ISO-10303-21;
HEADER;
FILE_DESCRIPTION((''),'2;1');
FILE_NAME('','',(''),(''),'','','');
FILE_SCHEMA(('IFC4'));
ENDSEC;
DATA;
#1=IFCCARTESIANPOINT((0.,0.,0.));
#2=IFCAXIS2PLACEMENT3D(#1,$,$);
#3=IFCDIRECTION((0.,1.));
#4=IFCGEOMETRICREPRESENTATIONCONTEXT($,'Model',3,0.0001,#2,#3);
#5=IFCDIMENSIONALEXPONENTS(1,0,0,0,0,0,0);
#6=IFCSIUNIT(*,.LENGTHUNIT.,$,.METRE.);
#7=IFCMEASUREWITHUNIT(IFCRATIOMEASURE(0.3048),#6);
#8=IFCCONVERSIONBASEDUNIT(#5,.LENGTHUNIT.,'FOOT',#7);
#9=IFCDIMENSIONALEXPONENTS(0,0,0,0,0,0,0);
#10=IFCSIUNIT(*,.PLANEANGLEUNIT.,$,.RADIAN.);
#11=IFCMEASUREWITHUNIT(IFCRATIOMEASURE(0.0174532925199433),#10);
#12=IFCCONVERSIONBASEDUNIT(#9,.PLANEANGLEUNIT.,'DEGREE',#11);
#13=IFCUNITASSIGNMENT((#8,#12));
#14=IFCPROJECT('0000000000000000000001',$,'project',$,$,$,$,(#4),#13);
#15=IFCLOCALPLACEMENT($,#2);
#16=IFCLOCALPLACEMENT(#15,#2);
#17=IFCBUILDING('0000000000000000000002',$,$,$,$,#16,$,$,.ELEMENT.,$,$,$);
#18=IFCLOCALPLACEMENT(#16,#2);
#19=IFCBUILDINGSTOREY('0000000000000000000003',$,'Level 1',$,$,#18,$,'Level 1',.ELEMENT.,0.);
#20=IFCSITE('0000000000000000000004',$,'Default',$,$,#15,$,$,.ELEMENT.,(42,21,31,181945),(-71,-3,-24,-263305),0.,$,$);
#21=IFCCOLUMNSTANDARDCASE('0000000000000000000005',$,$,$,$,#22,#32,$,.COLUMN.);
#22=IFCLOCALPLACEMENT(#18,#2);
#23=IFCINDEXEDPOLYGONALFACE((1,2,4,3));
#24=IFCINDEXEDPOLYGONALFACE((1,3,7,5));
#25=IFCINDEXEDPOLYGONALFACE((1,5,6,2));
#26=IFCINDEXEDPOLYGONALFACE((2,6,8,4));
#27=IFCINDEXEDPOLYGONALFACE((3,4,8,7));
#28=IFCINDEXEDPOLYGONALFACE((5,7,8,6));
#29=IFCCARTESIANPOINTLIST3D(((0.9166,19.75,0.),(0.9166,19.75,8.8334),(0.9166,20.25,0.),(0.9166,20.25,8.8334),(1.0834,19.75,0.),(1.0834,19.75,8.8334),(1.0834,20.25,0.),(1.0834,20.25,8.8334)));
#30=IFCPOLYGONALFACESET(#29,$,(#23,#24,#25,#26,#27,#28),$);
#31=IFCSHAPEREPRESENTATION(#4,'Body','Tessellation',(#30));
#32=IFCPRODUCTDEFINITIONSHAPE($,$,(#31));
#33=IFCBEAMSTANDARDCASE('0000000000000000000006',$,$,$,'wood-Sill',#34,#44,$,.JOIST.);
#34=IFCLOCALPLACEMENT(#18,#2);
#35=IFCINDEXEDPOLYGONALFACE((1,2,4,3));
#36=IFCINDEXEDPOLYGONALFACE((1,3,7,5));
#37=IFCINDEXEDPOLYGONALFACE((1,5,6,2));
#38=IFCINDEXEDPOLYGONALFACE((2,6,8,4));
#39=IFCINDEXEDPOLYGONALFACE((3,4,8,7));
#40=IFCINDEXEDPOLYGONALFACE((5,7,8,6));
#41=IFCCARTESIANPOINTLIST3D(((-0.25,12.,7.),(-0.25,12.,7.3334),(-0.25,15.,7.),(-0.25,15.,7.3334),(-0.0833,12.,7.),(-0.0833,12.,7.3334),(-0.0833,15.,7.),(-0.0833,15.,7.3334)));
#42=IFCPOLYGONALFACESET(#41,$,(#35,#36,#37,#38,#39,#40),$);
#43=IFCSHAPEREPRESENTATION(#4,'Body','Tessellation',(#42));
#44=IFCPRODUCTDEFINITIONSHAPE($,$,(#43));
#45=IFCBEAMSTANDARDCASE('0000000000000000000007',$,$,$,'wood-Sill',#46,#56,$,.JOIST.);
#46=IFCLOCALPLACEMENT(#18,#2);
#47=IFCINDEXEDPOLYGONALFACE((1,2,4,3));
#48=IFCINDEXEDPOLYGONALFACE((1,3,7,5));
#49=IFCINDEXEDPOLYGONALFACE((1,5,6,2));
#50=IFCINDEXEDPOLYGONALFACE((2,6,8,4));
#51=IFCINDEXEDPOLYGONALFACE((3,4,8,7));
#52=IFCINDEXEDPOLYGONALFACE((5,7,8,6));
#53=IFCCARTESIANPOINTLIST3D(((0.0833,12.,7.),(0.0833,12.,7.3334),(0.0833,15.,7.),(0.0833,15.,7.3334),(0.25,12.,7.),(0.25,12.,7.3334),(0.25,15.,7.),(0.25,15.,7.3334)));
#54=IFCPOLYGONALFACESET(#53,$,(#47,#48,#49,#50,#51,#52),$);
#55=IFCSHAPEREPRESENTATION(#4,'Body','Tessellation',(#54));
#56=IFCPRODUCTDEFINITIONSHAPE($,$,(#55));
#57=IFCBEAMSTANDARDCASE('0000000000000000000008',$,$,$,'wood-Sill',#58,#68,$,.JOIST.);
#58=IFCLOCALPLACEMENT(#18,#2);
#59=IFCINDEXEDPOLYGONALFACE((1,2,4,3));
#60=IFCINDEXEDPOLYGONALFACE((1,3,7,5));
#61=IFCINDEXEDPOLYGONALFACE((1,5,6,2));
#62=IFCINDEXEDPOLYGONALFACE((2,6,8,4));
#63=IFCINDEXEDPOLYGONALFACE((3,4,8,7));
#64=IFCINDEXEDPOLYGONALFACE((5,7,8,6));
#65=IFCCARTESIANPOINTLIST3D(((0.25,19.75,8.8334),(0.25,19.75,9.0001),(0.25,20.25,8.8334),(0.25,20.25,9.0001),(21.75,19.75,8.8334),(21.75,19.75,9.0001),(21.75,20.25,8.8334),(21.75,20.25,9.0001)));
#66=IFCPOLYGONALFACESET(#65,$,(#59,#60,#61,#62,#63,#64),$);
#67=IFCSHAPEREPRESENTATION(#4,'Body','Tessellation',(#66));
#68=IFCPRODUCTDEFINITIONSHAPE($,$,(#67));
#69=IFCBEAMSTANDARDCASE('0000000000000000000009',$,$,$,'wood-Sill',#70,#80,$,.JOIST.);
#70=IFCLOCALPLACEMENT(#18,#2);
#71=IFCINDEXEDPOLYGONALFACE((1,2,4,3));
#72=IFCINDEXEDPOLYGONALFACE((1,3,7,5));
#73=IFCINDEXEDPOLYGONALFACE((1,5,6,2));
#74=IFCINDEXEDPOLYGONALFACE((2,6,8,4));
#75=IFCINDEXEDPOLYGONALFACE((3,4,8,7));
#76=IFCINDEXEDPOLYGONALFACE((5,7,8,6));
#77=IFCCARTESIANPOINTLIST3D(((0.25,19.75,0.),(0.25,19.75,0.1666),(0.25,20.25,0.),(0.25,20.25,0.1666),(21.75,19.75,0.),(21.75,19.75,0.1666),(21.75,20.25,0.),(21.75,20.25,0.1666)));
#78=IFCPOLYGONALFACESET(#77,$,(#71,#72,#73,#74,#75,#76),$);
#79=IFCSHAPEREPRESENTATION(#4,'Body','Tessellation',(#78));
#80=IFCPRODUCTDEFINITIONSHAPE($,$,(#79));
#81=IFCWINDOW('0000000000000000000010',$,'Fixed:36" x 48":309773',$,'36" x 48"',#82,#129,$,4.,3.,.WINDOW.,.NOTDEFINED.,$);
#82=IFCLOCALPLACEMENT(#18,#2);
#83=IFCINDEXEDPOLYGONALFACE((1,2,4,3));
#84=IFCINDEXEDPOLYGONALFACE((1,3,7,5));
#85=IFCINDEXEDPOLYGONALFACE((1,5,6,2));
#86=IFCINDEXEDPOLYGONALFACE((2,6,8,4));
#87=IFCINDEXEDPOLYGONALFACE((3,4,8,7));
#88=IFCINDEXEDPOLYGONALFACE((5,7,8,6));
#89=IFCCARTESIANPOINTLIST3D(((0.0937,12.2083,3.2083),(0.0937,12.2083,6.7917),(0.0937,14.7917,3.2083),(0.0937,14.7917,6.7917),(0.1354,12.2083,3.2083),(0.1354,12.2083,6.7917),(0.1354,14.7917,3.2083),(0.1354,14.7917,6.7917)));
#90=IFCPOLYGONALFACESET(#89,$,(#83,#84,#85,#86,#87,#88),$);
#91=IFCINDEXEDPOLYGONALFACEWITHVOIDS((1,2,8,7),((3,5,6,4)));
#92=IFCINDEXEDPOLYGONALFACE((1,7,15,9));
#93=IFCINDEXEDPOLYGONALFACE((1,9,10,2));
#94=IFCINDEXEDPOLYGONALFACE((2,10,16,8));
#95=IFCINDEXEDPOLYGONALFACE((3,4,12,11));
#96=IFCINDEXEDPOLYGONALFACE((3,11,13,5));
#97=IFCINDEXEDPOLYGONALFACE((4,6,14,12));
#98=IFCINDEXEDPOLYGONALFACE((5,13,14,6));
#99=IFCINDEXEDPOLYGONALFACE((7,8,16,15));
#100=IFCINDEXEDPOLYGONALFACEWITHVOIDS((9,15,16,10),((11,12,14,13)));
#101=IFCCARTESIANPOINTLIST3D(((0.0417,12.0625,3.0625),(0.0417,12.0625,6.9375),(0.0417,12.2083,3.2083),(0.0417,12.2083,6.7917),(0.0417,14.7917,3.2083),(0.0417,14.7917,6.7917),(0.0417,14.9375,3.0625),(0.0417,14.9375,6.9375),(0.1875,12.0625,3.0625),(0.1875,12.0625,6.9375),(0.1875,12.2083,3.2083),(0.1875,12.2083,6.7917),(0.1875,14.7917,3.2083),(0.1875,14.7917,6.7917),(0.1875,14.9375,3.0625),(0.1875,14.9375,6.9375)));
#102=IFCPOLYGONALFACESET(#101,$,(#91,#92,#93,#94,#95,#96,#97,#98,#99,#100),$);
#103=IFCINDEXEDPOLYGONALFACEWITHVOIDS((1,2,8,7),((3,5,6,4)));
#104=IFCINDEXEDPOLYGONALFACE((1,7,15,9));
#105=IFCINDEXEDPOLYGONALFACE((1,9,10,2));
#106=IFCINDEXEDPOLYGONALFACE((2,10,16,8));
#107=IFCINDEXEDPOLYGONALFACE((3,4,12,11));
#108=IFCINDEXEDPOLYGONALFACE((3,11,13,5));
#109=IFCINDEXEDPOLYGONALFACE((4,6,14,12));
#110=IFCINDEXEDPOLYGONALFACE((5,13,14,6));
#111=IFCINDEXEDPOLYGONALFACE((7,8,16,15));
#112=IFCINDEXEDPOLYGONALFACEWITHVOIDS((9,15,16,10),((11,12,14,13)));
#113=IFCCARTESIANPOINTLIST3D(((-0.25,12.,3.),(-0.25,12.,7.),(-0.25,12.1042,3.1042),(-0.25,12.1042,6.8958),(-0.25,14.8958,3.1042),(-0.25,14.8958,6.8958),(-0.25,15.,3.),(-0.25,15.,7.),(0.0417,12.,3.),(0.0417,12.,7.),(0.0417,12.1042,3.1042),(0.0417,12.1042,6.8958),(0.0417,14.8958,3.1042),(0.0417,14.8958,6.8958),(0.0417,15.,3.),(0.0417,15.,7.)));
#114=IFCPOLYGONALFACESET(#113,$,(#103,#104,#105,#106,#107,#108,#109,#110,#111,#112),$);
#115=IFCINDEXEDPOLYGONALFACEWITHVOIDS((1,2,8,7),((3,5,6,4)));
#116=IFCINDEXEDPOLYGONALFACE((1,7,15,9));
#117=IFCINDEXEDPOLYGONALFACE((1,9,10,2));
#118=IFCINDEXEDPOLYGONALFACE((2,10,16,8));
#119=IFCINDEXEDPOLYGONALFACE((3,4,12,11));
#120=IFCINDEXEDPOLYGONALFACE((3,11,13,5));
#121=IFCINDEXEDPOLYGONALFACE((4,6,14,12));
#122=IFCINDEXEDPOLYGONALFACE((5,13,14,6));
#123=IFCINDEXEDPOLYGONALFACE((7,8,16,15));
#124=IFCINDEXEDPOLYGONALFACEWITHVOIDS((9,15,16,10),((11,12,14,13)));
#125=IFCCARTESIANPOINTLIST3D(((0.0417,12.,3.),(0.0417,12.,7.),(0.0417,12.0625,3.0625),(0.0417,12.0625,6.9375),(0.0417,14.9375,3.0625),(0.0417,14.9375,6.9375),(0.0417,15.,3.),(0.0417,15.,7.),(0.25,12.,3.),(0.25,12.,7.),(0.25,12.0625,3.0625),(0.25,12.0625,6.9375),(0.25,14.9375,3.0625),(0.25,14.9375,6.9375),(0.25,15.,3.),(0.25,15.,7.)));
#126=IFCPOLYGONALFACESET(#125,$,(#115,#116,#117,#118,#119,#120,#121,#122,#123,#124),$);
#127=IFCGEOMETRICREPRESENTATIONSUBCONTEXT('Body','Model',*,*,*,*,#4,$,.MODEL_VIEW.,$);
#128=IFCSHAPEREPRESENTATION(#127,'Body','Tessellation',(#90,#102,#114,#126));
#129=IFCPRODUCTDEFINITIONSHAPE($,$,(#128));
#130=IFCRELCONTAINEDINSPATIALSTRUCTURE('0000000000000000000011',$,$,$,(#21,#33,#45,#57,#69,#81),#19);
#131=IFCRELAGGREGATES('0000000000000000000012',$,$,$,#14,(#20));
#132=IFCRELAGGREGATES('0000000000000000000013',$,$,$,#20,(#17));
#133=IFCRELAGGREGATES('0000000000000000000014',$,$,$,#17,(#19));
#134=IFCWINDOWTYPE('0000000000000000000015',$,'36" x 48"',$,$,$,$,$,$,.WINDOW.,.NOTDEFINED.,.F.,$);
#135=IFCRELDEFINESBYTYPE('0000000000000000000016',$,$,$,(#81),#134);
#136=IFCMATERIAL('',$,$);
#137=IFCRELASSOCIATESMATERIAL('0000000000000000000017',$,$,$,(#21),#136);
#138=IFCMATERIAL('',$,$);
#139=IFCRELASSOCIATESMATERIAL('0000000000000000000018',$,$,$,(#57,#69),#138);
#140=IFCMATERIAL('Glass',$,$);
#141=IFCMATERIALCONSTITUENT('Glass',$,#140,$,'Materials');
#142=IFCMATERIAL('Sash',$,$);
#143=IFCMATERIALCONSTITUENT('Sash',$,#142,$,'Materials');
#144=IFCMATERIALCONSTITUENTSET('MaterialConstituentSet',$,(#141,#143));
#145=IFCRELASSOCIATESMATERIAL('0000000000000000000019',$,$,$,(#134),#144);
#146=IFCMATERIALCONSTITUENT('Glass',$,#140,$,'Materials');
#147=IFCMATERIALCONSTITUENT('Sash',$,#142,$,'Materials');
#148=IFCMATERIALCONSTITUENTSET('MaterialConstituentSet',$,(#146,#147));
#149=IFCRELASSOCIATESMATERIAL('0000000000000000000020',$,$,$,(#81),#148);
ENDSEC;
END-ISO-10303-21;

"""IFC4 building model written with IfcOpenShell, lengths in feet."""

from ifc_helpers import new_model, entity, si_unit, converted_unit, direction, frame, frame_2d, origin, origin_with_axes, place, context, subcontext, project, spatial, polyline, rectangle, outline, extrude, source, transform, mapped, material, constituent, constituent_set, type_object, type_shapes, element, save


model = new_model("IFC4")

# Units and contexts
model_context = context("Model", 3, precision=0.0001, world=origin(), true_north=direction((0.0, 1.0)))
body_context = subcontext(model_context, "Body", "Model", "MODEL_VIEW")
ifc_project = project(units=[converted_unit("LENGTHUNIT", "FOOT", entity("IfcRatioMeasure", 0.3048), si_unit("LENGTHUNIT", "METRE"), dimensions=[1, 0, 0, 0, 0, 0, 0]), converted_unit("PLANEANGLEUNIT", "DEGREE", entity("IfcRatioMeasure", 0.0174532925199433), si_unit("PLANEANGLEUNIT", "RADIAN"), dimensions=[0, 0, 0, 0, 0, 0, 0])], contexts=[model_context])

# Site, building, storey
site_placement = place(None, origin())
site = spatial("IfcSite", under=ifc_project, at=site_placement, Name="Default", CompositionType="ELEMENT", RefLatitude=(42, 21, 31, 181945), RefLongitude=(-71, -3, -24, -263305), RefElevation=0.0)
building_placement = place(site_placement, origin())
building = spatial("IfcBuilding", under=site, at=building_placement, CompositionType="ELEMENT")
storey_placement = place(building_placement, origin())
storey = spatial("IfcBuildingStorey", under=building, at=storey_placement, Name="Level 1", LongName="Level 1", CompositionType="ELEMENT", Elevation=0.0)

# Column
placement_1 = place(storey_placement, frame((0.0, -0.25, 0.0), z_axis=(0.0, 0.0, 1.0), x_axis=(0.0, 1.0, 0.0)))
ifc_material_1 = material(Name="")
placement_2 = place(storey_placement, frame((0.25, 20.0, 0.0)))
for number, where, z_axis, x_axis in (
    (1, (0.75, 0.0, 0.0), (0.0, 0.0, 1.0), (1.0, 0.0, 0.0)),
):
    element("IfcColumnStandardCase", number, at=place(placement_2, frame(where, z_axis=z_axis, x_axis=x_axis)), inside=storey, material=ifc_material_1, PredefinedType="COLUMN", context=model_context, shape_type="SweptSolid", body=[
        extrude(rectangle(XDim=0.1667, YDim=0.5), origin(), (0.0, 0.0, 1.0), 8.8334),
    ])

# Beams
for number, where, z_axis, x_axis in (
    (2, (12.25, 0.1667, 7.1667), (1.0, 0.0, 0.0), (0.0, 0.0, 1.0)),
    (3, (12.25, -0.1667, 7.1667), (1.0, 0.0, 0.0), (0.0, 0.0, 1.0)),
):
    element("IfcBeamStandardCase", number, at=place(placement_1, frame(where, z_axis=z_axis, x_axis=x_axis)), inside=storey, ObjectType="wood-Sill", PredefinedType="JOIST", context=model_context, shape_type="SweptSolid", body=[
        extrude(rectangle(XDim=0.3333, YDim=0.1667), origin_with_axes(), (0.0, 0.0, 1.0), 3.0),
    ])
ifc_material_2 = material(Name="")
for number, where, z_axis, x_axis in (
    (4, (0.0, 0.0, 8.9167), (1.0, 0.0, 0.0), (0.0, 0.0, 1.0)),
    (5, (0.0, 0.0, 0.0833), (1.0, 0.0, 0.0), (0.0, 0.0, 1.0)),
):
    element("IfcBeamStandardCase", number, at=place(placement_2, frame(where, z_axis=z_axis, x_axis=x_axis)), inside=storey, material=ifc_material_2, ObjectType="wood-Sill", PredefinedType="JOIST", context=model_context, shape_type="SweptSolid", body=[
        extrude(rectangle(XDim=0.1667, YDim=0.5), origin_with_axes(), (0.0, 0.0, 1.0), 21.5),
    ])

# Window
ifc_material_3 = material(Name="Glass")
ifc_constituent_1 = constituent(ifc_material_3, Name="Glass", Category="Materials")
ifc_material_4 = material(Name="Sash")
ifc_constituent_2 = constituent(ifc_material_4, Name="Sash", Category="Materials")
ifc_constituent_set_1 = constituent_set(constituents=[ifc_constituent_1, ifc_constituent_2], Name="MaterialConstituentSet")
ifc_constituent_3 = constituent(ifc_material_3, Name="Glass", Category="Materials")
ifc_constituent_4 = constituent(ifc_material_4, Name="Sash", Category="Materials")
ifc_constituent_set_2 = constituent_set(constituents=[ifc_constituent_3, ifc_constituent_4], Name="MaterialConstituentSet")
window_type = type_object("IfcWindowType", Name="36\" x 48\"", ParameterTakesPrecedence=False, PartitioningType="NOTDEFINED", PredefinedType="WINDOW", material=ifc_constituent_set_2)
shared_shape = source(origin(), body_context, "Body", "SweptSolid", [
    extrude(rectangle(XDim=0.0417, YDim=2.5833, at=frame_2d((0.0, 0.0), x_axis=(1.0, 0.0))), frame((1.5, 0.3646, 0.2083), z_axis=(0.0, 0.0, 1.0), x_axis=(0.0, 1.0, 0.0)), (0.0, 0.0, 1.0), 3.5833),
    extrude(outline(polyline([(-1.4375, -1.9375), (1.4375, -1.9375), (1.4375, 1.9375), (-1.4375, 1.9375), (-1.4375, -1.9375)]), holes=[polyline([(-1.2917, -1.7917), (-1.2917, 1.7917), (1.2917, 1.7917), (1.2917, -1.7917), (-1.2917, -1.7917)])]), frame((1.5, 0.2917, 2.0), z_axis=(0.0, 1.0, 0.0), x_axis=(1.0, 0.0, 0.0)), (0.0, 0.0, 1.0), 0.1458),
    extrude(outline(polyline([(-1.5, -2.0), (1.5, -2.0), (1.5, 2.0), (-1.5, 2.0), (-1.5, -2.0)]), holes=[polyline([(-1.3958, -1.8958), (-1.3958, 1.8958), (1.3958, 1.8958), (1.3958, -1.8958), (-1.3958, -1.8958)])]), frame((1.5, 0.0, 2.0), z_axis=(0.0, 1.0, 0.0), x_axis=(1.0, 0.0, 0.0)), (0.0, 0.0, 1.0), 0.2917),
    extrude(outline(polyline([(-2.0, -1.5), (2.0, -1.5), (2.0, 1.5), (-2.0, 1.5), (-2.0, -1.5)]), holes=[polyline([(-1.9375, -1.4375), (-1.9375, 1.4375), (1.9375, 1.4375), (1.9375, -1.4375), (-1.9375, -1.4375)])]), frame((1.5, 0.2917, 2.0), z_axis=(0.0, 1.0, 0.0), x_axis=(0.0, 0.0, -1.0)), (0.0, 0.0, 1.0), 0.2083),
])
type_shapes(window_type, [shared_shape])
placement_3 = place(placement_1, frame((15.25, 0.25, 3.0)))
window_placement = place(placement_3, frame((0.0, 0.0, 0.0), z_axis=(0.0, 0.0, 1.0), x_axis=(-1.0, 0.0, 0.0)))
element("IfcWindow", 6, at=window_placement, inside=storey, type_object=window_type, material=ifc_constituent_set_1, Name="Fixed:36\" x 48\":309773", ObjectType="36\" x 48\"", OverallHeight=4.0, OverallWidth=3.0, PartitioningType="NOTDEFINED", PredefinedType="WINDOW", context=body_context, shape_type="MappedRepresentation", body=[
    mapped(shared_shape, transform((0.0, 0.0, 0.0), scale=1.0)),
])

save(model, "model.ifc")
